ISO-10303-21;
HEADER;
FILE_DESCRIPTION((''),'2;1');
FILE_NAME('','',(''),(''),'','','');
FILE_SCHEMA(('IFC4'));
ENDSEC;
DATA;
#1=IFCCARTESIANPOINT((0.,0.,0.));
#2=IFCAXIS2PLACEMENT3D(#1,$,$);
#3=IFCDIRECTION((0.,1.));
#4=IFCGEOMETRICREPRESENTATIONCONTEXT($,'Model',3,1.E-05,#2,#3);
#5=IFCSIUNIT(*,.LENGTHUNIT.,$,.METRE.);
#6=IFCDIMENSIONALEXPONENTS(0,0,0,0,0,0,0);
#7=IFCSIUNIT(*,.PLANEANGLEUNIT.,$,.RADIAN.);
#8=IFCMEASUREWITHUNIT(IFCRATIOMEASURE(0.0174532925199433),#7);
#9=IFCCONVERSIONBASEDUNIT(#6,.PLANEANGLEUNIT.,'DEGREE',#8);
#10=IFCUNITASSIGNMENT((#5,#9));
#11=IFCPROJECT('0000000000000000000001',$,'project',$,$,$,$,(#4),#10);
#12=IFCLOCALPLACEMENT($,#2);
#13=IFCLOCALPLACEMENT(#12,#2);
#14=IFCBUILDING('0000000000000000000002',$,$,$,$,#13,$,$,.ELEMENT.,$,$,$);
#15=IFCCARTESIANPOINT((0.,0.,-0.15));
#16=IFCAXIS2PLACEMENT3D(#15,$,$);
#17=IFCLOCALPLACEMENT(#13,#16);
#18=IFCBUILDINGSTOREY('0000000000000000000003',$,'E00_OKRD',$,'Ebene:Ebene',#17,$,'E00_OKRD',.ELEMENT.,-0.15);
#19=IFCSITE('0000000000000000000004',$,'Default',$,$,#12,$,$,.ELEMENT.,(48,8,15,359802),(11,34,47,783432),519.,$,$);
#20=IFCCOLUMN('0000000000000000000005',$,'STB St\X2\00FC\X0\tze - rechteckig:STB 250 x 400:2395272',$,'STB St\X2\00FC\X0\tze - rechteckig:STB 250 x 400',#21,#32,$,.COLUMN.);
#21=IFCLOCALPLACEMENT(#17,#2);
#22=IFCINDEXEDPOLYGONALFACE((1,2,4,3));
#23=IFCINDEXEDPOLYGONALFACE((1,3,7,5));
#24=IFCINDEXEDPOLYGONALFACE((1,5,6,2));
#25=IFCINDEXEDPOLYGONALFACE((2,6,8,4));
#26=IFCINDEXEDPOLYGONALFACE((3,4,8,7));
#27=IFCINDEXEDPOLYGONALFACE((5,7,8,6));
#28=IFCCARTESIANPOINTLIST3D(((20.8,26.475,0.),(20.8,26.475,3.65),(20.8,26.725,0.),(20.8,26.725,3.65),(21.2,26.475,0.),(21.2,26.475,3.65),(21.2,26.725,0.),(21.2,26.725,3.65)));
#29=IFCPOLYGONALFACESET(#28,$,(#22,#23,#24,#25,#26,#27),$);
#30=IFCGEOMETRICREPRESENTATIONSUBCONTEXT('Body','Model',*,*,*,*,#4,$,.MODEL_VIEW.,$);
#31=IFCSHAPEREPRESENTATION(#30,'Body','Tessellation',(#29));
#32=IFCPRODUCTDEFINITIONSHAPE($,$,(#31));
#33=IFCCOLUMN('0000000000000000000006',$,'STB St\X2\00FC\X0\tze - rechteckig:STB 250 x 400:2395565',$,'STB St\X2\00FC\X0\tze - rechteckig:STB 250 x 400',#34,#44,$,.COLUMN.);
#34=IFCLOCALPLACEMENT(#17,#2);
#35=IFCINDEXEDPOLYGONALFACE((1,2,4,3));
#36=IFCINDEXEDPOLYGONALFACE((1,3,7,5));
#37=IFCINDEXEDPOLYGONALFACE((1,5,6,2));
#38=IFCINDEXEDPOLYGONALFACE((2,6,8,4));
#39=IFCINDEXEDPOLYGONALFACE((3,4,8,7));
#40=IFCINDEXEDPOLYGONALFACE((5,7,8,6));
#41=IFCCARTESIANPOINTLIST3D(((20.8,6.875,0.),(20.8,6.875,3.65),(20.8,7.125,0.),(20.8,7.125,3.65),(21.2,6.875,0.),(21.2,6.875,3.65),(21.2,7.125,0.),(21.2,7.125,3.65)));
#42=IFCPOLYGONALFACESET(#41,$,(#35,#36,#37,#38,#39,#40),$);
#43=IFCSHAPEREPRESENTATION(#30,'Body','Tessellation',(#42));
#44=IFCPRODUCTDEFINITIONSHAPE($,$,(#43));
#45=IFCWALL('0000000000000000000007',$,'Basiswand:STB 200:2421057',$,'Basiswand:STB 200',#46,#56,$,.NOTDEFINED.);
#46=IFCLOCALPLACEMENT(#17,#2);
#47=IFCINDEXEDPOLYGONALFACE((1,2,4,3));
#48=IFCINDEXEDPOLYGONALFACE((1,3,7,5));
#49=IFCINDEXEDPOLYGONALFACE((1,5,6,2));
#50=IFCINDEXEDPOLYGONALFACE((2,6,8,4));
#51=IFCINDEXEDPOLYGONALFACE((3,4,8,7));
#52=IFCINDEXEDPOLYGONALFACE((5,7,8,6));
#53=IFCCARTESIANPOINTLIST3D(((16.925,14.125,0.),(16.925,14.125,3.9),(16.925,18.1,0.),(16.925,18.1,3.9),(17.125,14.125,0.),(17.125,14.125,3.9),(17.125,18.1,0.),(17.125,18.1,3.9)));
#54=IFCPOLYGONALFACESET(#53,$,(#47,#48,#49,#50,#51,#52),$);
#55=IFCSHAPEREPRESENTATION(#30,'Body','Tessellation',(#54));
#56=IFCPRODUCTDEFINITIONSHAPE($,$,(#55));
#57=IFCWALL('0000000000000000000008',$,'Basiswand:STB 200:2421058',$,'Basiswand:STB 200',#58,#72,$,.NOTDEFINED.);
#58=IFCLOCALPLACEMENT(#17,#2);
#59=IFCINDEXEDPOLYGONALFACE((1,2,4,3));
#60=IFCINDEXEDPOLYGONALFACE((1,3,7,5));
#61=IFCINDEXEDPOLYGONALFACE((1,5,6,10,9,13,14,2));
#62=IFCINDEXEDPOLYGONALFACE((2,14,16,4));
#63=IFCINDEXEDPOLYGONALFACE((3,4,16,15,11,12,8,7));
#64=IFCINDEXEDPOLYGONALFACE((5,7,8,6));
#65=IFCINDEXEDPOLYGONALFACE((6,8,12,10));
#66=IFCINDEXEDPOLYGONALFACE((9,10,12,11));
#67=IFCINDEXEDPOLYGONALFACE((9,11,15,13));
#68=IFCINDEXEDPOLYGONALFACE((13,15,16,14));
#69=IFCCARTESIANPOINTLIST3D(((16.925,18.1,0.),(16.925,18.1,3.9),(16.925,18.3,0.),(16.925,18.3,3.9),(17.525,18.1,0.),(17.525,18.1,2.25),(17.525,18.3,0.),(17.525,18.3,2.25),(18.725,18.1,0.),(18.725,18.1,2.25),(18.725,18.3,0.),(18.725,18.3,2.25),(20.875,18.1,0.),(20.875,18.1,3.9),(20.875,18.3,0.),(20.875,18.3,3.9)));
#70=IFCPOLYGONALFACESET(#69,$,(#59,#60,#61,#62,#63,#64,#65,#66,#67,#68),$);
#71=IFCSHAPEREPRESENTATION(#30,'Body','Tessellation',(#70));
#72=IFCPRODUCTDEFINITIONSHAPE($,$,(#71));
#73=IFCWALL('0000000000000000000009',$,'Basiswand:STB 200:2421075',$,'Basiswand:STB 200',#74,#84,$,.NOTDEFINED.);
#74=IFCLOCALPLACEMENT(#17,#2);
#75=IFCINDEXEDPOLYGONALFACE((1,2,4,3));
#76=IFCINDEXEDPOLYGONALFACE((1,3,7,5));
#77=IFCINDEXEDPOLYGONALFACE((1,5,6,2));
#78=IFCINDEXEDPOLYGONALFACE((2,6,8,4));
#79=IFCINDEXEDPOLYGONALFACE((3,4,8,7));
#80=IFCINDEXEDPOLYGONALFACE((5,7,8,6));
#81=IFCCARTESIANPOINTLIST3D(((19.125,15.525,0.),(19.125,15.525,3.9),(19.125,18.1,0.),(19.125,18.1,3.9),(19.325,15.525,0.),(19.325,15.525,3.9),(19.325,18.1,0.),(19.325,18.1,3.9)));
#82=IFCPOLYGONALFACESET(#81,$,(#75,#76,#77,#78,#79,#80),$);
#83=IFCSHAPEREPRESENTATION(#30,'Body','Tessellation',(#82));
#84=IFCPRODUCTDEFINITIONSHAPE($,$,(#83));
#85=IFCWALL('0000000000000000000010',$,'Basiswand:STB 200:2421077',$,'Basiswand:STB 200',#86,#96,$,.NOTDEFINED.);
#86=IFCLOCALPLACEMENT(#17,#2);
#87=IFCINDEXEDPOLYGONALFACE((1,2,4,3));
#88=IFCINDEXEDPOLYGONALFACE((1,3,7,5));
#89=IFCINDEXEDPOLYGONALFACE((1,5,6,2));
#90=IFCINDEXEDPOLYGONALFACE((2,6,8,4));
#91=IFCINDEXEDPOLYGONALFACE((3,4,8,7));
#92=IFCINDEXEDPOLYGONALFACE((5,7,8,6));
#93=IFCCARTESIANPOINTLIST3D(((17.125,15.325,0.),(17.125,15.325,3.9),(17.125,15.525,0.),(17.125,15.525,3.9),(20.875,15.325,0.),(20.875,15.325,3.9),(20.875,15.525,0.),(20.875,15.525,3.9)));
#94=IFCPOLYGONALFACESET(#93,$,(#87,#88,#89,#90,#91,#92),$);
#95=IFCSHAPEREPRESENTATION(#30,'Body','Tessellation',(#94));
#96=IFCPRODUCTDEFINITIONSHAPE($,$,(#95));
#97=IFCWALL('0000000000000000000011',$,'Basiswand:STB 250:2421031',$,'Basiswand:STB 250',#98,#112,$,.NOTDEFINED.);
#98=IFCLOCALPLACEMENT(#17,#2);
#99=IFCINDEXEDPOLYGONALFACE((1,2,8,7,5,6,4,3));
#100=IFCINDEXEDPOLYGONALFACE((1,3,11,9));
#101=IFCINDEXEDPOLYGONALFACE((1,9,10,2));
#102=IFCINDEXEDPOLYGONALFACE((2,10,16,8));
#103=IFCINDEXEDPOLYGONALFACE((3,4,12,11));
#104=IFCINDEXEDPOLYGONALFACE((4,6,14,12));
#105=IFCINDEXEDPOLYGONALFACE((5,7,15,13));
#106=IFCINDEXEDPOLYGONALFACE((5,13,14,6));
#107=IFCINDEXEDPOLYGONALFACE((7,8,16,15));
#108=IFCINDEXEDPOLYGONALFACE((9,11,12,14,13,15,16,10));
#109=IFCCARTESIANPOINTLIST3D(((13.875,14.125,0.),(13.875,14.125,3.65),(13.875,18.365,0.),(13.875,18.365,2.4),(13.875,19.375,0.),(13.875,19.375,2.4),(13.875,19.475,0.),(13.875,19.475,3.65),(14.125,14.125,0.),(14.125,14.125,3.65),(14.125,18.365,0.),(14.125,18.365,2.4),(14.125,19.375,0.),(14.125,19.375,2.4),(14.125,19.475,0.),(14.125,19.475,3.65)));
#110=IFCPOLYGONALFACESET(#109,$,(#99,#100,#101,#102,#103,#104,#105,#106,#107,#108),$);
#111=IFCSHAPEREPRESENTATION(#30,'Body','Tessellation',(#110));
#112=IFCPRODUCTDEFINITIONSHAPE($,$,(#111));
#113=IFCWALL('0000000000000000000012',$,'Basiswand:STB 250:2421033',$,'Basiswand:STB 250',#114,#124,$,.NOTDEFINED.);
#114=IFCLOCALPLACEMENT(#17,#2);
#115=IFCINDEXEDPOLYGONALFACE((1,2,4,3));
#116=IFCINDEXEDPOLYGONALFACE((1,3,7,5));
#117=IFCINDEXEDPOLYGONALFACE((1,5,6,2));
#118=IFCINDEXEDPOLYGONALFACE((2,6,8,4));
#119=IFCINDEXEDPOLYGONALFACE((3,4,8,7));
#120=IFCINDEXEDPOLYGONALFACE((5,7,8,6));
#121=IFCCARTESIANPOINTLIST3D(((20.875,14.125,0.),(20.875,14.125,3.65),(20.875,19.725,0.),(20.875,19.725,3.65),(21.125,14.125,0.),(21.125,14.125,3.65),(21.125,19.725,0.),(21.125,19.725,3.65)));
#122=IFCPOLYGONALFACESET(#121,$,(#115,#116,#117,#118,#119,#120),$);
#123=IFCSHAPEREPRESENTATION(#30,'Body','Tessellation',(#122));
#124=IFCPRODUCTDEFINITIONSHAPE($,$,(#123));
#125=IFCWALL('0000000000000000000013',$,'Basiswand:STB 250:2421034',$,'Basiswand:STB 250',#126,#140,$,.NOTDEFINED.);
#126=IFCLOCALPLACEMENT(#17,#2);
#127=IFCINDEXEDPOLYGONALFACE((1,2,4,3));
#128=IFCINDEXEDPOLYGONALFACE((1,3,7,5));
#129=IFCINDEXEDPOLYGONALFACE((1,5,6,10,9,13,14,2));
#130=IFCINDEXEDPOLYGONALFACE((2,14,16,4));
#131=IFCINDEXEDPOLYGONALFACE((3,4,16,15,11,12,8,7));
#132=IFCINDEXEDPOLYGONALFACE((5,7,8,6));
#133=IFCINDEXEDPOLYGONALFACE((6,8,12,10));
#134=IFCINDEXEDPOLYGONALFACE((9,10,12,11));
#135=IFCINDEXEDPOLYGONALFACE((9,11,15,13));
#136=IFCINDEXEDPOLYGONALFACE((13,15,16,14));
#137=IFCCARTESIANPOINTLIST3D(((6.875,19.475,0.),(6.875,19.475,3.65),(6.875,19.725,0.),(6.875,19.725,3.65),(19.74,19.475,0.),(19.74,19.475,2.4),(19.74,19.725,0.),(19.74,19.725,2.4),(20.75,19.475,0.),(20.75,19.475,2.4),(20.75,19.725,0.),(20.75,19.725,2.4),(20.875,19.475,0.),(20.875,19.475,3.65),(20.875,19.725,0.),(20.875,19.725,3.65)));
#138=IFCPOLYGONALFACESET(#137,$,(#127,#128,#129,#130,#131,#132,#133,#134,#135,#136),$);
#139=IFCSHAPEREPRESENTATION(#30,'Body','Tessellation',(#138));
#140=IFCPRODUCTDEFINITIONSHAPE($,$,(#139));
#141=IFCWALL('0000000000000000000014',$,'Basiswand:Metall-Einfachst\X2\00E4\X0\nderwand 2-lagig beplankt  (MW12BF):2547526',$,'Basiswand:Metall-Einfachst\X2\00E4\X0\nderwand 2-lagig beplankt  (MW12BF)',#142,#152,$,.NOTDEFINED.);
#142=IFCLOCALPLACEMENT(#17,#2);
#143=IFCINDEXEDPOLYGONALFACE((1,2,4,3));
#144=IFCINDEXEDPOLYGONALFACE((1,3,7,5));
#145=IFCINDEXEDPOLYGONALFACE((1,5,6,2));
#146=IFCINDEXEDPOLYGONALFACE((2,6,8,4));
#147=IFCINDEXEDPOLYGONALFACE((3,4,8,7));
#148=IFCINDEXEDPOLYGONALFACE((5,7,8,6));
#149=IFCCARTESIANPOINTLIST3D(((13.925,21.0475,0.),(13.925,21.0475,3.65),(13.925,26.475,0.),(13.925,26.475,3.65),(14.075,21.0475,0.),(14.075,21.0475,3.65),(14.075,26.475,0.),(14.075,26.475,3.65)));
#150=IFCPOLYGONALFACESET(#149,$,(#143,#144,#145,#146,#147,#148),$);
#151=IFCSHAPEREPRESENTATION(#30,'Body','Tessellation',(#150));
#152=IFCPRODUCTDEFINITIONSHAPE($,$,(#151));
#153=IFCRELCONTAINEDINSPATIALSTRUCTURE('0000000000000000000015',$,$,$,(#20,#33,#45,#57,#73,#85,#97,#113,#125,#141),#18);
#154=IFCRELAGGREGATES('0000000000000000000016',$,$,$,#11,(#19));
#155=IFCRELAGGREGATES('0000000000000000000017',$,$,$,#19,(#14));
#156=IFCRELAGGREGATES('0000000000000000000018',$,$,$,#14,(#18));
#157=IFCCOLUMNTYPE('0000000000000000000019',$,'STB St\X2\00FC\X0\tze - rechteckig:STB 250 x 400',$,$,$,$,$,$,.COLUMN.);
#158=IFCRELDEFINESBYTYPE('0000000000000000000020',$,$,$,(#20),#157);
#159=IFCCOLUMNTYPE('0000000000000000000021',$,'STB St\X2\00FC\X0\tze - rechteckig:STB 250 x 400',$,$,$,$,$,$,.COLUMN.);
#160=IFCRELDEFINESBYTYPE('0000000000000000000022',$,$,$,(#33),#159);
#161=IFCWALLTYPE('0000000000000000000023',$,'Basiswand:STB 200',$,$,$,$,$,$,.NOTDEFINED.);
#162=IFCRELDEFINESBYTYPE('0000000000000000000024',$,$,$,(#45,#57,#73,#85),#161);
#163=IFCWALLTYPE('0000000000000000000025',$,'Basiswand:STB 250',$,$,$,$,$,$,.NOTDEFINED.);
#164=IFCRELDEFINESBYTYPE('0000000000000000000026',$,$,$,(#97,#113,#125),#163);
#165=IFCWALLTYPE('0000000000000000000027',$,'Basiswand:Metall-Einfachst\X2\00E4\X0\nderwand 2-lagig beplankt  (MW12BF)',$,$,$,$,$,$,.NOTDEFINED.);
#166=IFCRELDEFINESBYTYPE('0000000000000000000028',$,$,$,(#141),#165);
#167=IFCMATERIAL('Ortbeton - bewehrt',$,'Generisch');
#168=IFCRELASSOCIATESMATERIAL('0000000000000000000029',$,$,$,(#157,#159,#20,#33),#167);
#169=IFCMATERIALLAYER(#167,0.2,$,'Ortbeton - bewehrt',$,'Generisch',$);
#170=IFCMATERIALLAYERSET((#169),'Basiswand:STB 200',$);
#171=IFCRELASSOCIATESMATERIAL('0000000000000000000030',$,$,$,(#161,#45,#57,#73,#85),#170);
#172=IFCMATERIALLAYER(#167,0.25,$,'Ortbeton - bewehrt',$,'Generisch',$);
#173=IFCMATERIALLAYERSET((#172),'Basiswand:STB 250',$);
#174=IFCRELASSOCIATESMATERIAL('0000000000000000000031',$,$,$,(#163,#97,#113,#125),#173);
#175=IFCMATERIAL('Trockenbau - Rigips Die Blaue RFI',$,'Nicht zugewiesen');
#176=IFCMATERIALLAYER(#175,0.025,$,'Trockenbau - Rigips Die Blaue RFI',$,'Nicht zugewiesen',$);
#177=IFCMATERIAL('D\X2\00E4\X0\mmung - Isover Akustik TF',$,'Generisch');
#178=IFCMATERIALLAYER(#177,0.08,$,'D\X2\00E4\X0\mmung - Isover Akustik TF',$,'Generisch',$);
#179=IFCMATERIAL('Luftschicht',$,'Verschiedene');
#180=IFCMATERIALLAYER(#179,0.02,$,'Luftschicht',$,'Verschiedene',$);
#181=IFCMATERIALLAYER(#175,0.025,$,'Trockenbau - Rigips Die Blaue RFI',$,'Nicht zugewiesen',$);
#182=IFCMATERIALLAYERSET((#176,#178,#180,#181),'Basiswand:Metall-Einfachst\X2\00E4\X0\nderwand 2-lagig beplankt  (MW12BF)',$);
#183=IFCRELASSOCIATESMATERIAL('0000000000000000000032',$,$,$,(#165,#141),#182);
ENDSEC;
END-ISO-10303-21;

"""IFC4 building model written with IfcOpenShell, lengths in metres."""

from ifc_helpers import new_model, entity, si_unit, converted_unit, direction, frame, frame_2d, origin, origin_2d_with_axis, place, context, subcontext, project, spatial, rectangle, extrude, source, transform, mapped, material, layer, layer_set, layer_usage, material_profile, profile_set, profile_usage, type_object, type_shapes, element, save


model = new_model("IFC4")

# Units and contexts
model_context = context("Model", 3, precision=1e-05, world=origin(), true_north=direction((0.0, 1.0)))
body_context = subcontext(model_context, "Body", "Model", "MODEL_VIEW")
ifc_project = project(units=[si_unit("LENGTHUNIT", "METRE"), converted_unit("PLANEANGLEUNIT", "DEGREE", entity("IfcRatioMeasure", 0.0174532925199433), si_unit("PLANEANGLEUNIT", "RADIAN"), dimensions=[0, 0, 0, 0, 0, 0, 0])], contexts=[model_context])

# Site, building, storey
site_placement = place(None, frame((0.0, 0.0, 0.0)))
site = spatial("IfcSite", under=ifc_project, at=site_placement, Name="Default", CompositionType="ELEMENT", RefLatitude=(48, 8, 15, 359802), RefLongitude=(11, 34, 47, 783432), RefElevation=519.0)
building_placement = place(site_placement, origin())
building = spatial("IfcBuilding", under=site, at=building_placement, CompositionType="ELEMENT")
storey_placement = place(building_placement, frame((0.0, 0.0, -0.15)))
storey = spatial("IfcBuildingStorey", under=building, at=storey_placement, Name="E00_OKRD", ObjectType="Ebene:Ebene", LongName="E00_OKRD", CompositionType="ELEMENT", Elevation=-0.15)

# Columns
ifc_material_1 = material(Name="Ortbeton - bewehrt", Category="Generisch")
ifc_material_profile = material_profile(ifc_material_1, rectangle(XDim=0.4, YDim=0.25, at=frame_2d((0.0, 0.0), x_axis=(1.0, 0.0))), Name="STB 250 x 400")
ifc_profile_set = profile_set([ifc_material_profile], Name="STB 250 x 400")
ifc_profile_usage_1 = profile_usage(ifc_profile_set)
column_type_1 = type_object("IfcColumnType", Name="STB Stütze - rechteckig:STB 250 x 400", PredefinedType="COLUMN", material=ifc_profile_set)
shared_shape_1 = source(origin(), body_context, "Body", "SweptSolid", [
    extrude(rectangle(XDim=0.4, YDim=0.25, at=frame_2d((0.0, 0.0), x_axis=(1.0, 0.0))), frame((0.2, 0.125, 0.0), z_axis=(0.0, 0.0, 1.0), x_axis=(-1.0, 0.0, 0.0)), (0.0, 0.0, 1.0), 3.65),
])
type_shapes(column_type_1, [shared_shape_1])
column_1_placement = place(storey_placement, frame((20.8, 26.475, 0.0)))
element("IfcColumn", 1, at=column_1_placement, inside=storey, type_object=column_type_1, material=ifc_profile_usage_1, Name="STB Stütze - rechteckig:STB 250 x 400:2395272", ObjectType="STB Stütze - rechteckig:STB 250 x 400", PredefinedType="COLUMN", context=body_context, shape_type="MappedRepresentation", body=[
    mapped(shared_shape_1, transform((0.0, 0.0, 0.0), scale=1.0)),
])
ifc_profile_usage_2 = profile_usage(ifc_profile_set)
column_type_2 = type_object("IfcColumnType", Name="STB Stütze - rechteckig:STB 250 x 400", PredefinedType="COLUMN", material=ifc_profile_set)
shared_shape_2 = source(origin(), body_context, "Body", "SweptSolid", [
    extrude(rectangle(XDim=0.4, YDim=0.25, at=frame_2d((0.0, 0.0), x_axis=(1.0, 0.0))), frame((0.2, 0.125, 0.0), z_axis=(0.0, 0.0, 1.0), x_axis=(-1.0, 0.0, 0.0)), (0.0, 0.0, 1.0), 3.65),
])
type_shapes(column_type_2, [shared_shape_2])
column_2_placement = place(storey_placement, frame((20.8, 6.875, 0.0)))
element("IfcColumn", 2, at=column_2_placement, inside=storey, type_object=column_type_2, material=ifc_profile_usage_2, Name="STB Stütze - rechteckig:STB 250 x 400:2395565", ObjectType="STB Stütze - rechteckig:STB 250 x 400", PredefinedType="COLUMN", context=body_context, shape_type="MappedRepresentation", body=[
    mapped(shared_shape_2, transform((0.0, 0.0, 0.0), scale=1.0)),
])

# Wall
ifc_layer_1 = layer(ifc_material_1, 0.2, Name="Ortbeton - bewehrt", Category="Generisch")
ifc_layer_set_1 = layer_set([ifc_layer_1], Name="Basiswand:STB 200")
ifc_layer_usage_1 = layer_usage(ifc_layer_set_1, "AXIS2", "POSITIVE", -0.1)
wall_type_1 = type_object("IfcWallType", Name="Basiswand:STB 200", PredefinedType="NOTDEFINED", material=ifc_layer_set_1)
wall_1_placement = place(storey_placement, frame((17.025, 14.125, 0.0), z_axis=(0.0, 0.0, 1.0), x_axis=(0.0, 1.0, 0.0)))
element("IfcWall", 3, at=wall_1_placement, inside=storey, type_object=wall_type_1, material=ifc_layer_usage_1, Name="Basiswand:STB 200:2421057", ObjectType="Basiswand:STB 200", PredefinedType="NOTDEFINED", context=body_context, shape_type="SweptSolid", body=[
    extrude(rectangle(XDim=3.975, YDim=0.2, at=frame_2d((1.9875, 0.0), x_axis=(-1.0, 0.0))), origin(), (0.0, 0.0, 1.0), 3.9),
])

# Wall, opening
ifc_layer_usage_2 = layer_usage(ifc_layer_set_1, "AXIS2", "POSITIVE", -0.1)
wall_2_placement = place(storey_placement, frame((16.925, 18.2, 0.0)))
wall_2 = element("IfcWall", 4, at=wall_2_placement, inside=storey, type_object=wall_type_1, material=ifc_layer_usage_2, Name="Basiswand:STB 200:2421058", ObjectType="Basiswand:STB 200", PredefinedType="NOTDEFINED", context=body_context, shape_type="SweptSolid", body=[
    extrude(rectangle(XDim=3.95, YDim=0.2, at=frame_2d((1.975, 0.0), x_axis=(-1.0, 0.0))), origin(), (0.0, 0.0, 1.0), 3.9),
])
opening_1_placement = place(wall_2_placement, frame((0.6, -0.1, 0.0)))
element("IfcOpeningElement", 5, at=opening_1_placement, cuts=wall_2, ObjectType="Opening", PredefinedType="OPENING", context=body_context, shape_type="SweptSolid", body=[
    extrude(rectangle(XDim=2.25, YDim=1.2, at=frame_2d((1.125, 0.6), x_axis=(1.0, 0.0))), frame((0.0, 0.0, 0.0), z_axis=(0.0, 1.0, 0.0), x_axis=(0.0, 0.0, 1.0)), (0.0, 0.0, 1.0), 0.2),
])

# Walls
ifc_layer_usage_3 = layer_usage(ifc_layer_set_1, "AXIS2", "NEGATIVE", 0.1)
wall_3_placement = place(storey_placement, frame((19.225, 15.525, 0.0), z_axis=(0.0, 0.0, 1.0), x_axis=(0.0, 1.0, 0.0)))
element("IfcWall", 6, at=wall_3_placement, inside=storey, type_object=wall_type_1, material=ifc_layer_usage_3, Name="Basiswand:STB 200:2421075", ObjectType="Basiswand:STB 200", PredefinedType="NOTDEFINED", context=body_context, shape_type="SweptSolid", body=[
    extrude(rectangle(XDim=2.575, YDim=0.2, at=frame_2d((1.2875, 0.0), x_axis=(-1.0, 0.0))), origin(), (0.0, 0.0, 1.0), 3.9),
])
ifc_layer_usage_4 = layer_usage(ifc_layer_set_1, "AXIS2", "POSITIVE", -0.1)
wall_4_placement = place(storey_placement, frame((17.125, 15.425, 0.0)))
element("IfcWall", 7, at=wall_4_placement, inside=storey, type_object=wall_type_1, material=ifc_layer_usage_4, Name="Basiswand:STB 200:2421077", ObjectType="Basiswand:STB 200", PredefinedType="NOTDEFINED", context=body_context, shape_type="SweptSolid", body=[
    extrude(rectangle(XDim=3.75, YDim=0.2, at=frame_2d((1.875, 0.0), x_axis=(-1.0, 0.0))), origin(), (0.0, 0.0, 1.0), 3.9),
])

# Wall, opening
ifc_layer_2 = layer(ifc_material_1, 0.25, Name="Ortbeton - bewehrt", Category="Generisch")
ifc_layer_set_2 = layer_set([ifc_layer_2], Name="Basiswand:STB 250")
ifc_layer_usage_5 = layer_usage(ifc_layer_set_2, "AXIS2", "POSITIVE", -0.125)
wall_type_2 = type_object("IfcWallType", Name="Basiswand:STB 250", PredefinedType="NOTDEFINED", material=ifc_layer_set_2)
wall_5_placement = place(storey_placement, frame((14.0, 14.125, 0.0), z_axis=(0.0, 0.0, 1.0), x_axis=(0.0, 1.0, 0.0)))
wall_5 = element("IfcWall", 8, at=wall_5_placement, inside=storey, type_object=wall_type_2, material=ifc_layer_usage_5, Name="Basiswand:STB 250:2421031", ObjectType="Basiswand:STB 250", PredefinedType="NOTDEFINED", context=body_context, shape_type="SweptSolid", body=[
    extrude(rectangle(XDim=5.35, YDim=0.25, at=frame_2d((2.675, 0.0), x_axis=(-1.0, 0.0))), origin(), (0.0, 0.0, 1.0), 3.65),
])
opening_2_placement = place(wall_5_placement, frame((4.24, 0.125, 0.0), z_axis=(0.0, 0.0, 1.0), x_axis=(0.0, -1.0, 0.0)))
element("IfcOpeningElement", 9, at=opening_2_placement, cuts=wall_5, ObjectType="Opening", PredefinedType="OPENING", context=body_context, shape_type="SweptSolid", body=[
    extrude(rectangle(XDim=2.4, YDim=1.01, at=frame_2d((0.0, 0.0), x_axis=(0.0, 1.0))), frame((0.25, 0.505, 1.2), z_axis=(-1.0, 0.0, 0.0), x_axis=(0.0, 1.0, 0.0)), (0.0, 0.0, 1.0), 0.25),
    extrude(rectangle(XDim=2.27, YDim=0.95, at=frame_2d((0.0, 0.0), x_axis=(0.0, 1.0))), frame((0.55, 0.505, 1.235), z_axis=(-1.0, 0.0, 0.0), x_axis=(0.0, 1.0, 0.0)), (0.0, 0.0, 1.0), 0.255),
])

# Wall
ifc_layer_usage_6 = layer_usage(ifc_layer_set_2, "AXIS2", "POSITIVE", -0.125)
wall_6_placement = place(storey_placement, frame((21.0, 14.125, 0.0), z_axis=(0.0, 0.0, 1.0), x_axis=(0.0, 1.0, 0.0)))
element("IfcWall", 10, at=wall_6_placement, inside=storey, type_object=wall_type_2, material=ifc_layer_usage_6, Name="Basiswand:STB 250:2421033", ObjectType="Basiswand:STB 250", PredefinedType="NOTDEFINED", context=body_context, shape_type="SweptSolid", body=[
    extrude(rectangle(XDim=5.6, YDim=0.25, at=frame_2d((2.8, 0.0), x_axis=(-1.0, 0.0))), origin(), (0.0, 0.0, 1.0), 3.65),
])

# Wall, opening
ifc_layer_usage_7 = layer_usage(ifc_layer_set_2, "AXIS2", "POSITIVE", -0.125)
wall_7_placement = place(storey_placement, frame((20.875, 19.6, 0.0), z_axis=(0.0, 0.0, 1.0), x_axis=(-1.0, 0.0, 0.0)))
wall_7 = element("IfcWall", 11, at=wall_7_placement, inside=storey, type_object=wall_type_2, material=ifc_layer_usage_7, Name="Basiswand:STB 250:2421034", ObjectType="Basiswand:STB 250", PredefinedType="NOTDEFINED", context=body_context, shape_type="SweptSolid", body=[
    extrude(rectangle(XDim=14.0, YDim=0.25, at=frame_2d((7.0, 0.0), x_axis=(-1.0, 0.0))), origin(), (0.0, 0.0, 1.0), 3.65),
])
opening_3_placement = place(wall_7_placement, frame((1.135, 0.125, 0.0), z_axis=(0.0, 0.0, 1.0), x_axis=(-1.0, 0.0, 0.0)))
element("IfcOpeningElement", 12, at=opening_3_placement, cuts=wall_7, ObjectType="Opening", PredefinedType="OPENING", context=body_context, shape_type="SweptSolid", body=[
    extrude(rectangle(XDim=2.4, YDim=1.01, at=origin_2d_with_axis()), frame((0.505, 0.25, 1.2), z_axis=(0.0, -1.0, 0.0), x_axis=(0.0, 0.0, -1.0)), (0.0, 0.0, 1.0), 0.25),
    extrude(rectangle(XDim=2.27, YDim=0.95, at=origin_2d_with_axis()), frame((0.505, 0.55, 1.235), z_axis=(0.0, -1.0, 0.0), x_axis=(0.0, 0.0, -1.0)), (0.0, 0.0, 1.0), 0.255),
])

# Wall
ifc_material_2 = material(Name="Trockenbau - Rigips Die Blaue RFI", Category="Nicht zugewiesen")
ifc_layer_3 = layer(ifc_material_2, 0.025, Name="Trockenbau - Rigips Die Blaue RFI", Category="Nicht zugewiesen")
ifc_material_3 = material(Name="Dämmung - Isover Akustik TF", Category="Generisch")
ifc_layer_4 = layer(ifc_material_3, 0.08, Name="Dämmung - Isover Akustik TF", Category="Generisch")
ifc_material_4 = material(Name="Luftschicht", Category="Verschiedene")
ifc_layer_5 = layer(ifc_material_4, 0.02, Name="Luftschicht", Category="Verschiedene")
ifc_layer_6 = layer(ifc_material_2, 0.025, Name="Trockenbau - Rigips Die Blaue RFI", Category="Nicht zugewiesen")
ifc_layer_set_3 = layer_set([ifc_layer_3, ifc_layer_4, ifc_layer_5, ifc_layer_6], Name="Basiswand:Metall-Einfachständerwand 2-lagig beplankt  (MW12BF)")
ifc_layer_usage_8 = layer_usage(ifc_layer_set_3, "AXIS2", "NEGATIVE", 0.075)
wall_type_3 = type_object("IfcWallType", Name="Basiswand:Metall-Einfachständerwand 2-lagig beplankt  (MW12BF)", PredefinedType="NOTDEFINED", material=ifc_layer_set_3)
wall_8_placement = place(storey_placement, frame((14.0, 26.475, 0.0), z_axis=(0.0, 0.0, 1.0), x_axis=(0.0, -1.0, 0.0)))
element("IfcWall", 13, at=wall_8_placement, inside=storey, type_object=wall_type_3, material=ifc_layer_usage_8, Name="Basiswand:Metall-Einfachständerwand 2-lagig beplankt  (MW12BF):2547526", ObjectType="Basiswand:Metall-Einfachständerwand 2-lagig beplankt  (MW12BF)", PredefinedType="NOTDEFINED", context=body_context, shape_type="SweptSolid", body=[
    extrude(rectangle(XDim=5.4275, YDim=0.15, at=frame_2d((2.7137, 0.0), x_axis=(-1.0, 0.0))), origin(), (0.0, 0.0, 1.0), 3.65),
])

save(model, "model.ifc")
